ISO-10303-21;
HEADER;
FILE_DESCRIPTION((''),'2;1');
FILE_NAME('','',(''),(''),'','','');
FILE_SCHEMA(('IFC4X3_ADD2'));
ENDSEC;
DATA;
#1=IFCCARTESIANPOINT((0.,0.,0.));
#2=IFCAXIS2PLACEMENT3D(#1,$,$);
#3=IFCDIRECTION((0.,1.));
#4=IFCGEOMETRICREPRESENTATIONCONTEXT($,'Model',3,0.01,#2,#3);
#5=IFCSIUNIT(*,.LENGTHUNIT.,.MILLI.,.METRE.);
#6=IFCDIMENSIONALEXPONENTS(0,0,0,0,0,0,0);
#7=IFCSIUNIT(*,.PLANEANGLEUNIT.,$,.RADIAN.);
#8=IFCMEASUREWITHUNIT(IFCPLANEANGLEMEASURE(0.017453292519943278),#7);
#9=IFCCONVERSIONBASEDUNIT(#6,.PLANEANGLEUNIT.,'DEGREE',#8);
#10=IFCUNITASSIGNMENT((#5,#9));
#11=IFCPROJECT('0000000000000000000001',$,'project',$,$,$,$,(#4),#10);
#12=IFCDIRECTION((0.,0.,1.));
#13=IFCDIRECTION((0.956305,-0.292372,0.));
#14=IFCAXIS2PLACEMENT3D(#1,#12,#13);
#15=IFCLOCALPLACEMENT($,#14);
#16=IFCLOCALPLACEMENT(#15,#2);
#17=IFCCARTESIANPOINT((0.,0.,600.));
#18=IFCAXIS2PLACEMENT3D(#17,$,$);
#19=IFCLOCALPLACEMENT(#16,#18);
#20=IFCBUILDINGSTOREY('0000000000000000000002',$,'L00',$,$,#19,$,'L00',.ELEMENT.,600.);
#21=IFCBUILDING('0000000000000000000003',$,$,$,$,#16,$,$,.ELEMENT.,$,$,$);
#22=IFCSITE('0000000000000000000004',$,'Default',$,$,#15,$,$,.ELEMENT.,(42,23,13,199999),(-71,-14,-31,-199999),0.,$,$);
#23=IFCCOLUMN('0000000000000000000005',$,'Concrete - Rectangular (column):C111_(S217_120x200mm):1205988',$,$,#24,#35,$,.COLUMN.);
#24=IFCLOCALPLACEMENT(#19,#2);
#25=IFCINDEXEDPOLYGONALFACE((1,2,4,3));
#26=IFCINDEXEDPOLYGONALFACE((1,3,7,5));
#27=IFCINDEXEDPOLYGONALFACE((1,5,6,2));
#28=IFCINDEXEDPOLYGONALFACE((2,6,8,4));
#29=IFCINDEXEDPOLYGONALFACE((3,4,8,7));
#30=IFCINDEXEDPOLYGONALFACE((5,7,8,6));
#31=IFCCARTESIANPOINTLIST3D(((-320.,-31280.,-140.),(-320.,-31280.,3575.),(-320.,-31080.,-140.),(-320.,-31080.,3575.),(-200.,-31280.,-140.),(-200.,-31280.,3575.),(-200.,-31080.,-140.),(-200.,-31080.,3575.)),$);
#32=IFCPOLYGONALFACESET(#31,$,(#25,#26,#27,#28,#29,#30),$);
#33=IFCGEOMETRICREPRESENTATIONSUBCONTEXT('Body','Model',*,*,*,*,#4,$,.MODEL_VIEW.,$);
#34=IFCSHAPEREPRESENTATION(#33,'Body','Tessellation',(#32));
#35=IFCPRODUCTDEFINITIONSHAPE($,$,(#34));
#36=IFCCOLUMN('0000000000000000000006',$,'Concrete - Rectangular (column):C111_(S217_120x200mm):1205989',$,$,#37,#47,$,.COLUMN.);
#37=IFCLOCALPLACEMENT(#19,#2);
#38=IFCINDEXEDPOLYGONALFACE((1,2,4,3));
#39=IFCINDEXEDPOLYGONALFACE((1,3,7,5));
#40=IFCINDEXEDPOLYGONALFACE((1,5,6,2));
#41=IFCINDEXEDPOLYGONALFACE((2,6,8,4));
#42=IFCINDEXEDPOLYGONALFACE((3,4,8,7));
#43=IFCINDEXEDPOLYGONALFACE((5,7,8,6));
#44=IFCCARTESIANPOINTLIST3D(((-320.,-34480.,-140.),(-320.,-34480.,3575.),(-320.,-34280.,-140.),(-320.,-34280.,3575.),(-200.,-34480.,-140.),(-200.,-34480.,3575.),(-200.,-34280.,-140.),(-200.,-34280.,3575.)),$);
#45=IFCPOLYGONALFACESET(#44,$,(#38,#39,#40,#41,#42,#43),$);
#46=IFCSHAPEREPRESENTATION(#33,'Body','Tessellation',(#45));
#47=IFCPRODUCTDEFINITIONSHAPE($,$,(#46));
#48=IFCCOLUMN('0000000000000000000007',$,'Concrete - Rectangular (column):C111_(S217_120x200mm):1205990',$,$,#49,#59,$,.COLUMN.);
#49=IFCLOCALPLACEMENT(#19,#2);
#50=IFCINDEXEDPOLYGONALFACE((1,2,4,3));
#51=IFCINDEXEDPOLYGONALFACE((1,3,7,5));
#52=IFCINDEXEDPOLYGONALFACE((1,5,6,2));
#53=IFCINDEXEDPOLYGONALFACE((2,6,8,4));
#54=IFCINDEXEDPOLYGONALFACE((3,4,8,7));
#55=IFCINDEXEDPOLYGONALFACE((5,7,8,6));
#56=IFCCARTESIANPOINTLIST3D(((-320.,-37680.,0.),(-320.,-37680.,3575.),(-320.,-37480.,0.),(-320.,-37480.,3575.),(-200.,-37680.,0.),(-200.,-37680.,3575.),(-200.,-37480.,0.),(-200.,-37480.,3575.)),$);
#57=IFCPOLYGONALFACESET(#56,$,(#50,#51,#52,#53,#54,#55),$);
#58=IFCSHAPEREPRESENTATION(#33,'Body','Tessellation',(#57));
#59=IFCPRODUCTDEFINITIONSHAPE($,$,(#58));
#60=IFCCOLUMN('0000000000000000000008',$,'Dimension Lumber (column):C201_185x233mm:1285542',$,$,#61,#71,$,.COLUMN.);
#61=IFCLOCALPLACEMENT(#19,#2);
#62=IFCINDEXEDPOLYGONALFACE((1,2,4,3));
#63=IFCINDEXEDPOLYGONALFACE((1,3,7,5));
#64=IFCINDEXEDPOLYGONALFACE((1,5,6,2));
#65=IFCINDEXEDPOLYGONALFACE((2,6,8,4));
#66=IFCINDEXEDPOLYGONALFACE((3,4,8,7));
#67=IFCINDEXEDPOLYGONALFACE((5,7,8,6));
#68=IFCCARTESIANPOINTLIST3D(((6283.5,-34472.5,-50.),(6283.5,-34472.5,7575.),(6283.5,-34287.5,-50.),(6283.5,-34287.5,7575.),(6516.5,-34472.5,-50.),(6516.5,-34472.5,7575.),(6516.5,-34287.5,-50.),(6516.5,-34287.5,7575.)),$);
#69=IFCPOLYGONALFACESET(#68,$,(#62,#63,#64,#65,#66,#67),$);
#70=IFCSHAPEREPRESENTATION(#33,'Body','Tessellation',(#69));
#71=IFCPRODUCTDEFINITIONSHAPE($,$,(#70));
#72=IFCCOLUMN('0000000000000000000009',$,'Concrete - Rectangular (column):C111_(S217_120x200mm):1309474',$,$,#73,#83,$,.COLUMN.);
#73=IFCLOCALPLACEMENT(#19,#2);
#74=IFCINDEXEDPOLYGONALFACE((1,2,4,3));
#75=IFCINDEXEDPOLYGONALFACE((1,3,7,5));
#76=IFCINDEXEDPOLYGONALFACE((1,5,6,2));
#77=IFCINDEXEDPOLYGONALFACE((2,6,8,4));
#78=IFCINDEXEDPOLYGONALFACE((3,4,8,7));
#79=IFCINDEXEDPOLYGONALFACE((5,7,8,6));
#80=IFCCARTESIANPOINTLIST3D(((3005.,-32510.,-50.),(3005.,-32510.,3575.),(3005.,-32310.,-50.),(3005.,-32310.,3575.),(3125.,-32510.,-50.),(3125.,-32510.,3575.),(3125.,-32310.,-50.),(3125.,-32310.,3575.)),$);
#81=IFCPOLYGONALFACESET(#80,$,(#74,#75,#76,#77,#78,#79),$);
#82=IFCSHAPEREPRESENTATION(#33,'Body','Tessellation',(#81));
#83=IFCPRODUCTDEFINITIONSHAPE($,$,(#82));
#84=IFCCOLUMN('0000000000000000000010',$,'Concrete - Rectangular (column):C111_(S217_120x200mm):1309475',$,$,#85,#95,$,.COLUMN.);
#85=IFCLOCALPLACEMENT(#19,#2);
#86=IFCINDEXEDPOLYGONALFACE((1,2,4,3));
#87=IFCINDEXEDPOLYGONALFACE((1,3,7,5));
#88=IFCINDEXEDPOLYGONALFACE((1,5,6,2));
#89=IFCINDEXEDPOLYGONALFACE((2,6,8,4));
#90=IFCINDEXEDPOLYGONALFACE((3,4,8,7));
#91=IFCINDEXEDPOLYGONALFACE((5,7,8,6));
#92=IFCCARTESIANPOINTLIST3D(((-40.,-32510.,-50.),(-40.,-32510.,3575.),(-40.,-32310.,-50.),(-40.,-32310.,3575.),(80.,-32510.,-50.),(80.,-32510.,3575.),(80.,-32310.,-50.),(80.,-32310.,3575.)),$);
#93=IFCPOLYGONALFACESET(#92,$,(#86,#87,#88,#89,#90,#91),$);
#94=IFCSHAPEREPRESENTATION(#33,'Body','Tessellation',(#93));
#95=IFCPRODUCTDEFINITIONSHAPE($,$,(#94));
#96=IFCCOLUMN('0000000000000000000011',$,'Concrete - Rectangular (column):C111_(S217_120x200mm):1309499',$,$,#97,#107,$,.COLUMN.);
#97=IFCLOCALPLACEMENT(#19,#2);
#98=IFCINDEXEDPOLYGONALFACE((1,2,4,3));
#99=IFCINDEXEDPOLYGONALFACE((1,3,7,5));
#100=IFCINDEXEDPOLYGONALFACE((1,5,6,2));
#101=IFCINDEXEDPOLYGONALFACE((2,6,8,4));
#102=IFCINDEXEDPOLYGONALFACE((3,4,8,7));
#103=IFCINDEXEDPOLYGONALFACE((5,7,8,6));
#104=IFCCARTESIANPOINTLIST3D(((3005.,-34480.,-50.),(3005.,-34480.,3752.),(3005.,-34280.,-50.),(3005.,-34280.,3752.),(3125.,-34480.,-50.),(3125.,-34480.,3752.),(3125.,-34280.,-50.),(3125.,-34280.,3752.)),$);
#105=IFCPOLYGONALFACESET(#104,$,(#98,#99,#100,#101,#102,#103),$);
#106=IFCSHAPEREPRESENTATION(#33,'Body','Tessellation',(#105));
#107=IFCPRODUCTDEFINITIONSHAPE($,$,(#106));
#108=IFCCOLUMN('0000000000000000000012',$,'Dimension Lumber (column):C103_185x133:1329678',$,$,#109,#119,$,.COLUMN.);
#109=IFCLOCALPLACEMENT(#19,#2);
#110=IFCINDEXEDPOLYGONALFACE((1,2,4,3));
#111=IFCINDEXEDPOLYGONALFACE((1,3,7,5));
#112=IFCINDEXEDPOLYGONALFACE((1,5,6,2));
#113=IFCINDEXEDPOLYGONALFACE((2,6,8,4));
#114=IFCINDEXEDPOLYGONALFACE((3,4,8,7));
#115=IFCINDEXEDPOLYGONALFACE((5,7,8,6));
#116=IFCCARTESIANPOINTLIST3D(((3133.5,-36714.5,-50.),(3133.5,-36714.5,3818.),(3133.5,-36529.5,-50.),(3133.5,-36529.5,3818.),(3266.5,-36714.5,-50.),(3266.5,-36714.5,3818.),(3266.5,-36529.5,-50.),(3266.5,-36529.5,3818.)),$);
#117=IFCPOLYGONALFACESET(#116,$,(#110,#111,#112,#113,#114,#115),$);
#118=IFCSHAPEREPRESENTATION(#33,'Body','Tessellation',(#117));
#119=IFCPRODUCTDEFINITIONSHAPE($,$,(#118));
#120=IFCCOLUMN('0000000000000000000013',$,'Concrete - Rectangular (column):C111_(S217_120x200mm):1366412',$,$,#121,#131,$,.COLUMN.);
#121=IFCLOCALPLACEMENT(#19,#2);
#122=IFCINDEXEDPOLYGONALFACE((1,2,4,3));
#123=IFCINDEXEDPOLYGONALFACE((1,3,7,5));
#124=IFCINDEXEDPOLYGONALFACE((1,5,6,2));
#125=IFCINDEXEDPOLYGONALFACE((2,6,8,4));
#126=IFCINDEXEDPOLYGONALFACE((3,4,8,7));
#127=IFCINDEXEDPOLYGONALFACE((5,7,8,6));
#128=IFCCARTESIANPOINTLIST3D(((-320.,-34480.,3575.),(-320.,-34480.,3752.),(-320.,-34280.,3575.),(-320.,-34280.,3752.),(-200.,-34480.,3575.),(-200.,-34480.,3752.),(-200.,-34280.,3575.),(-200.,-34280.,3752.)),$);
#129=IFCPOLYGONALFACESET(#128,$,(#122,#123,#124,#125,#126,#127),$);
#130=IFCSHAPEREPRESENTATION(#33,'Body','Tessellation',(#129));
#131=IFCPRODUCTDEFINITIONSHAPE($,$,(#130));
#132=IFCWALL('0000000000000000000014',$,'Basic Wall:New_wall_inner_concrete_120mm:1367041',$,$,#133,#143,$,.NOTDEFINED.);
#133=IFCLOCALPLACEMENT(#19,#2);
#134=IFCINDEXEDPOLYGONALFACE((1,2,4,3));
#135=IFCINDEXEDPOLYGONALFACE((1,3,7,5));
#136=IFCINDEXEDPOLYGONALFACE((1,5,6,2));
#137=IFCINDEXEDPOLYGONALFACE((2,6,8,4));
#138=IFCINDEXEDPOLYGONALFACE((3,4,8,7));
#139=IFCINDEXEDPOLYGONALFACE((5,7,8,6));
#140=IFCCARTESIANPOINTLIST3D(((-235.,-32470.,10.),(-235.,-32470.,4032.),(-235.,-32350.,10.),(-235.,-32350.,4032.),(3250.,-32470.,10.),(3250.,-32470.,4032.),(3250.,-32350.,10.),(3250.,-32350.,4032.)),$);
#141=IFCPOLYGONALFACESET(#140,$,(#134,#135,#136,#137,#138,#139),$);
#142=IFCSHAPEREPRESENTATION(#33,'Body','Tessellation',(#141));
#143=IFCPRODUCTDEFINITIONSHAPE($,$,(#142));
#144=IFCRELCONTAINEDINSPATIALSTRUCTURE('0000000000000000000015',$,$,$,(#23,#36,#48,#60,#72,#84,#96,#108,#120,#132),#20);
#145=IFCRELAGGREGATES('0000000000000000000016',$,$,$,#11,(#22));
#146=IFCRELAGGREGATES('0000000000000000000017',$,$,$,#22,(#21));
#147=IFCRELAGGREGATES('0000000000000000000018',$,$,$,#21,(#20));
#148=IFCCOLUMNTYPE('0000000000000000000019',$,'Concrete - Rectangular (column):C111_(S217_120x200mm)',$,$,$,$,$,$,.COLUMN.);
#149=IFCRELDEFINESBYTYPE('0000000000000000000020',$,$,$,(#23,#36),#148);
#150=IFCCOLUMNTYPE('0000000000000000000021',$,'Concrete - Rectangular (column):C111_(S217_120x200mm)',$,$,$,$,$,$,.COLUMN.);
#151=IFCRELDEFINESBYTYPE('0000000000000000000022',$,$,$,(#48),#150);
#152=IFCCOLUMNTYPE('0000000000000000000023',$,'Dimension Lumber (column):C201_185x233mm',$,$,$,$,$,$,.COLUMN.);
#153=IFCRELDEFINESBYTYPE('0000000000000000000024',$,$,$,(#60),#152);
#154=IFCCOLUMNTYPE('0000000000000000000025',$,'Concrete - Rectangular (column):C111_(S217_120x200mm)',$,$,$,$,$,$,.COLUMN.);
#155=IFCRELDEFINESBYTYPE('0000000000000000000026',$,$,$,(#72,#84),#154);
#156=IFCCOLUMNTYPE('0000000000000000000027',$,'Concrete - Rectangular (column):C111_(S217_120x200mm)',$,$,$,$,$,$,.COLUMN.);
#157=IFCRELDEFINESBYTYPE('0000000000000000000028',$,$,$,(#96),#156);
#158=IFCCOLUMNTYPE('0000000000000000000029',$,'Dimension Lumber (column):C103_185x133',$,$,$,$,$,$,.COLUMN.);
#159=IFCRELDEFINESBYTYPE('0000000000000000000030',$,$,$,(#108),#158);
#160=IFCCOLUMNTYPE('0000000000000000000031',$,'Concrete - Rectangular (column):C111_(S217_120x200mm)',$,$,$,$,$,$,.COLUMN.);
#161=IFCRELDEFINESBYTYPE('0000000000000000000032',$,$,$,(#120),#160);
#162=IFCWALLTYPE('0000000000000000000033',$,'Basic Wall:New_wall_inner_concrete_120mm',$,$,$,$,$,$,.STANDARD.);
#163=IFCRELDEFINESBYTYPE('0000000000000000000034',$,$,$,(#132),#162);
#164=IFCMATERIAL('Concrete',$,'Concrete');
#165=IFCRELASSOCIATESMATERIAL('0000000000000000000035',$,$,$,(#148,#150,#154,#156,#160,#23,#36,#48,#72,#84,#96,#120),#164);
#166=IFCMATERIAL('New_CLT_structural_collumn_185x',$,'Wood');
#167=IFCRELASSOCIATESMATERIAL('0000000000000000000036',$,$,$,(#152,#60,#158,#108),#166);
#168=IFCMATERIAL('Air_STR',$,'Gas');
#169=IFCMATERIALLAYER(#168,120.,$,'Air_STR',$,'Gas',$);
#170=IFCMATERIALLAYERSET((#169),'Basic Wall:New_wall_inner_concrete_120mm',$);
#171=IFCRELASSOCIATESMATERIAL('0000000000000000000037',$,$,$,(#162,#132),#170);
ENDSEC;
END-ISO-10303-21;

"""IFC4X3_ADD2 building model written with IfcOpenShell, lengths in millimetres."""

from ifc_helpers import new_model, entity, si_unit, converted_unit, direction, frame, frame_2d, origin, origin_2d_with_axis, place, context, subcontext, project, spatial, rectangle, extrude, source, transform, mapped, material, layer, layer_set, material_profile, profile_set, profile_usage, type_object, type_shapes, element, save


model = new_model("IFC4X3_ADD2")

# Units and contexts
model_context = context("Model", 3, precision=0.01, world=origin(), true_north=direction((0.0, 1.0)))
body_context = subcontext(model_context, "Body", "Model", "MODEL_VIEW")
ifc_project = project(units=[si_unit("LENGTHUNIT", "METRE", prefix="MILLI"), converted_unit("PLANEANGLEUNIT", "DEGREE", entity("IfcPlaneAngleMeasure", 0.017453292519943278), si_unit("PLANEANGLEUNIT", "RADIAN"), dimensions=[0, 0, 0, 0, 0, 0, 0])], contexts=[model_context])

# Site, building, storey
site_placement = place(None, frame((0.0, 0.0, 0.0), z_axis=(0.0, 0.0, 1.0), x_axis=(0.956305, -0.292372, 0.0)))
site = spatial("IfcSite", under=ifc_project, at=site_placement, Name="Default", CompositionType="ELEMENT", RefLatitude=(42, 23, 13, 199999), RefLongitude=(-71, -14, -31, -199999), RefElevation=0.0)
building_placement = place(site_placement, origin())
building = spatial("IfcBuilding", under=site, at=building_placement, CompositionType="ELEMENT")
storey_placement = place(building_placement, frame((0.0, 0.0, 600.0)))
storey = spatial("IfcBuildingStorey", under=building, at=storey_placement, Name="L00", LongName="L00", CompositionType="ELEMENT", Elevation=600.0)

# Columns
ifc_material_1 = material(Name="Concrete", Category="Concrete")
ifc_material_profile_1 = material_profile(ifc_material_1, rectangle(XDim=120.0, YDim=200.0, at=frame_2d((0.0, 0.0), x_axis=(1.0, 0.0))), Name="C111_(S217_120x200mm)")
ifc_profile_set_1 = profile_set([ifc_material_profile_1], Name="C111_(S217_120x200mm)")
ifc_profile_usage_1 = profile_usage(ifc_profile_set_1)
column_type_1 = type_object("IfcColumnType", Name="Concrete - Rectangular (column):C111_(S217_120x200mm)", PredefinedType="COLUMN", material=ifc_profile_set_1)
shared_shape_1 = source(origin(), body_context, "Body", "SweptSolid", [
    extrude(rectangle(XDim=120.0, YDim=200.0, at=origin_2d_with_axis()), frame((0.0, 0.0, 460.0), z_axis=(0.0, 0.0, 1.0), x_axis=(-1.0, 0.0, 0.0)), (0.0, 0.0, 1.0), 3715.0),
])
type_shapes(column_type_1, [shared_shape_1])
for number, where, name in (
    (1, (-260.0, -31180.0, -600.0), "Concrete - Rectangular (column):C111_(S217_120x200mm):1205988"),
    (2, (-260.0, -34380.0, -600.0), "Concrete - Rectangular (column):C111_(S217_120x200mm):1205989"),
):
    element("IfcColumn", number, at=place(storey_placement, frame(where)), inside=storey, type_object=column_type_1, material=ifc_profile_usage_1, Name=name, PredefinedType="COLUMN", context=body_context, shape_type="MappedRepresentation", body=[
        mapped(shared_shape_1, transform((0.0, 0.0, 0.0), scale=1.0)),
    ])
column_type_2 = type_object("IfcColumnType", Name="Concrete - Rectangular (column):C111_(S217_120x200mm)", PredefinedType="COLUMN", material=ifc_profile_set_1)
shared_shape_2 = source(origin(), body_context, "Body", "SweptSolid", [
    extrude(rectangle(XDim=120.0, YDim=200.0, at=origin_2d_with_axis()), frame((0.0, 0.0, 600.0), z_axis=(0.0, 0.0, 1.0), x_axis=(-1.0, 0.0, 0.0)), (0.0, 0.0, 1.0), 3575.0),
])
type_shapes(column_type_2, [shared_shape_2])
column_1_placement = place(storey_placement, frame((-260.0, -37580.0, -600.0)))
element("IfcColumn", 3, at=column_1_placement, inside=storey, type_object=column_type_2, material=ifc_profile_usage_1, Name="Concrete - Rectangular (column):C111_(S217_120x200mm):1205990", PredefinedType="COLUMN", context=body_context, shape_type="MappedRepresentation", body=[
    mapped(shared_shape_2, transform((0.0, 0.0, 0.0), scale=1.0)),
])
ifc_material_2 = material(Name="New_CLT_structural_collumn_185x", Category="Wood")
ifc_material_profile_2 = material_profile(ifc_material_2, rectangle(XDim=185.0, YDim=233.0, at=origin_2d_with_axis()), Name="C201_185x233mm")
ifc_profile_set_2 = profile_set([ifc_material_profile_2], Name="C201_185x233mm")
ifc_profile_usage_2 = profile_usage(ifc_profile_set_2)
column_type_3 = type_object("IfcColumnType", Name="Dimension Lumber (column):C201_185x233mm", PredefinedType="COLUMN", material=ifc_profile_set_2)
shared_shape_3 = source(origin(), body_context, "Body", "SweptSolid", [
    extrude(rectangle(XDim=185.0, YDim=233.0, at=origin_2d_with_axis()), frame((0.0, 0.0, 550.0), z_axis=(0.0, 0.0, 1.0), x_axis=(-1.0, 0.0, 0.0)), (0.0, 0.0, 1.0), 7625.0),
])
type_shapes(column_type_3, [shared_shape_3])
column_2_placement = place(storey_placement, frame((6400.0, -34380.0, -600.0), z_axis=(0.0, 0.0, 1.0), x_axis=(0.0, 1.0, 0.0)))
element("IfcColumn", 4, at=column_2_placement, inside=storey, type_object=column_type_3, material=ifc_profile_usage_2, Name="Dimension Lumber (column):C201_185x233mm:1285542", PredefinedType="COLUMN", context=body_context, shape_type="MappedRepresentation", body=[
    mapped(shared_shape_3, transform((0.0, 0.0, 0.0), scale=1.0)),
])
column_type_4 = type_object("IfcColumnType", Name="Concrete - Rectangular (column):C111_(S217_120x200mm)", PredefinedType="COLUMN", material=ifc_profile_set_1)
shared_shape_4 = source(origin(), body_context, "Body", "SweptSolid", [
    extrude(rectangle(XDim=120.0, YDim=200.0, at=origin_2d_with_axis()), frame((0.0, 0.0, 550.0), z_axis=(0.0, 0.0, 1.0), x_axis=(-1.0, 0.0, 0.0)), (0.0, 0.0, 1.0), 3625.0),
])
type_shapes(column_type_4, [shared_shape_4])
for number, where, name in (
    (5, (3065.0, -32410.0, -600.0), "Concrete - Rectangular (column):C111_(S217_120x200mm):1309474"),
    (6, (20.0, -32410.0, -600.0), "Concrete - Rectangular (column):C111_(S217_120x200mm):1309475"),
):
    element("IfcColumn", number, at=place(storey_placement, frame(where)), inside=storey, type_object=column_type_4, material=ifc_profile_usage_1, Name=name, PredefinedType="COLUMN", context=body_context, shape_type="MappedRepresentation", body=[
        mapped(shared_shape_4, transform((0.0, 0.0, 0.0), scale=1.0)),
    ])
column_type_5 = type_object("IfcColumnType", Name="Concrete - Rectangular (column):C111_(S217_120x200mm)", PredefinedType="COLUMN", material=ifc_profile_set_1)
shared_shape_5 = source(origin(), body_context, "Body", "SweptSolid", [
    extrude(rectangle(XDim=120.0, YDim=200.0, at=origin_2d_with_axis()), frame((0.0, 0.0, 550.0), z_axis=(0.0, 0.0, 1.0), x_axis=(-1.0, 0.0, 0.0)), (0.0, 0.0, 1.0), 3802.0),
])
type_shapes(column_type_5, [shared_shape_5])
column_3_placement = place(storey_placement, frame((3065.0, -34380.0, -600.0)))
element("IfcColumn", 7, at=column_3_placement, inside=storey, type_object=column_type_5, material=ifc_profile_usage_1, Name="Concrete - Rectangular (column):C111_(S217_120x200mm):1309499", PredefinedType="COLUMN", context=body_context, shape_type="MappedRepresentation", body=[
    mapped(shared_shape_5, transform((0.0, 0.0, 0.0), scale=1.0)),
])
ifc_material_profile_3 = material_profile(ifc_material_2, rectangle(XDim=185.0, YDim=133.0, at=origin_2d_with_axis()), Name="C103_185x133")
ifc_profile_set_3 = profile_set([ifc_material_profile_3], Name="C103_185x133")
ifc_profile_usage_3 = profile_usage(ifc_profile_set_3)
column_type_6 = type_object("IfcColumnType", Name="Dimension Lumber (column):C103_185x133", PredefinedType="COLUMN", material=ifc_profile_set_3)
shared_shape_6 = source(origin(), body_context, "Body", "SweptSolid", [
    extrude(rectangle(XDim=185.0, YDim=133.0, at=origin_2d_with_axis()), frame((0.0, 0.0, 550.0), z_axis=(0.0, 0.0, 1.0), x_axis=(-1.0, 0.0, 0.0)), (0.0, 0.0, 1.0), 3868.0),
])
type_shapes(column_type_6, [shared_shape_6])
column_4_placement = place(storey_placement, frame((3200.0, -36622.0, -600.0), z_axis=(0.0, 0.0, 1.0), x_axis=(0.0, -1.0, 0.0)))
element("IfcColumn", 8, at=column_4_placement, inside=storey, type_object=column_type_6, material=ifc_profile_usage_3, Name="Dimension Lumber (column):C103_185x133:1329678", PredefinedType="COLUMN", context=body_context, shape_type="MappedRepresentation", body=[
    mapped(shared_shape_6, transform((0.0, 0.0, 0.0), scale=1.0)),
])
column_type_7 = type_object("IfcColumnType", Name="Concrete - Rectangular (column):C111_(S217_120x200mm)", PredefinedType="COLUMN", material=ifc_profile_set_1)
shared_shape_7 = source(origin(), body_context, "Body", "SweptSolid", [
    extrude(rectangle(XDim=120.0, YDim=200.0, at=origin_2d_with_axis()), frame((0.0, 0.0, 4175.0), z_axis=(0.0, 0.0, 1.0), x_axis=(-1.0, 0.0, 0.0)), (0.0, 0.0, 1.0), 177.0),
])
type_shapes(column_type_7, [shared_shape_7])
column_5_placement = place(storey_placement, frame((-260.0, -34380.0, -600.0)))
element("IfcColumn", 9, at=column_5_placement, inside=storey, type_object=column_type_7, material=ifc_profile_usage_1, Name="Concrete - Rectangular (column):C111_(S217_120x200mm):1366412", PredefinedType="COLUMN", context=body_context, shape_type="MappedRepresentation", body=[
    mapped(shared_shape_7, transform((0.0, 0.0, 0.0), scale=1.0)),
])

# Wall
ifc_material_3 = material(Name="Air_STR", Category="Gas")
ifc_layer = layer(ifc_material_3, 120.0, Name="Air_STR", Category="Gas")
ifc_layer_set = layer_set([ifc_layer], Name="Basic Wall:New_wall_inner_concrete_120mm")
wall_type = type_object("IfcWallType", Name="Basic Wall:New_wall_inner_concrete_120mm", PredefinedType="STANDARD", material=ifc_layer_set)
wall_placement = place(storey_placement, frame((-235.0, -32410.0, 10.0)))
element("IfcWall", 10, at=wall_placement, inside=storey, type_object=wall_type, material=ifc_layer_set, Name="Basic Wall:New_wall_inner_concrete_120mm:1367041", PredefinedType="NOTDEFINED", context=body_context, shape_type="SweptSolid", body=[
    extrude(rectangle(XDim=3485.0, YDim=120.0, at=frame_2d((1742.5, 0.0), x_axis=(-1.0, 0.0))), origin(), (0.0, 0.0, 1.0), 4022.0),
])

save(model, "model.ifc")
